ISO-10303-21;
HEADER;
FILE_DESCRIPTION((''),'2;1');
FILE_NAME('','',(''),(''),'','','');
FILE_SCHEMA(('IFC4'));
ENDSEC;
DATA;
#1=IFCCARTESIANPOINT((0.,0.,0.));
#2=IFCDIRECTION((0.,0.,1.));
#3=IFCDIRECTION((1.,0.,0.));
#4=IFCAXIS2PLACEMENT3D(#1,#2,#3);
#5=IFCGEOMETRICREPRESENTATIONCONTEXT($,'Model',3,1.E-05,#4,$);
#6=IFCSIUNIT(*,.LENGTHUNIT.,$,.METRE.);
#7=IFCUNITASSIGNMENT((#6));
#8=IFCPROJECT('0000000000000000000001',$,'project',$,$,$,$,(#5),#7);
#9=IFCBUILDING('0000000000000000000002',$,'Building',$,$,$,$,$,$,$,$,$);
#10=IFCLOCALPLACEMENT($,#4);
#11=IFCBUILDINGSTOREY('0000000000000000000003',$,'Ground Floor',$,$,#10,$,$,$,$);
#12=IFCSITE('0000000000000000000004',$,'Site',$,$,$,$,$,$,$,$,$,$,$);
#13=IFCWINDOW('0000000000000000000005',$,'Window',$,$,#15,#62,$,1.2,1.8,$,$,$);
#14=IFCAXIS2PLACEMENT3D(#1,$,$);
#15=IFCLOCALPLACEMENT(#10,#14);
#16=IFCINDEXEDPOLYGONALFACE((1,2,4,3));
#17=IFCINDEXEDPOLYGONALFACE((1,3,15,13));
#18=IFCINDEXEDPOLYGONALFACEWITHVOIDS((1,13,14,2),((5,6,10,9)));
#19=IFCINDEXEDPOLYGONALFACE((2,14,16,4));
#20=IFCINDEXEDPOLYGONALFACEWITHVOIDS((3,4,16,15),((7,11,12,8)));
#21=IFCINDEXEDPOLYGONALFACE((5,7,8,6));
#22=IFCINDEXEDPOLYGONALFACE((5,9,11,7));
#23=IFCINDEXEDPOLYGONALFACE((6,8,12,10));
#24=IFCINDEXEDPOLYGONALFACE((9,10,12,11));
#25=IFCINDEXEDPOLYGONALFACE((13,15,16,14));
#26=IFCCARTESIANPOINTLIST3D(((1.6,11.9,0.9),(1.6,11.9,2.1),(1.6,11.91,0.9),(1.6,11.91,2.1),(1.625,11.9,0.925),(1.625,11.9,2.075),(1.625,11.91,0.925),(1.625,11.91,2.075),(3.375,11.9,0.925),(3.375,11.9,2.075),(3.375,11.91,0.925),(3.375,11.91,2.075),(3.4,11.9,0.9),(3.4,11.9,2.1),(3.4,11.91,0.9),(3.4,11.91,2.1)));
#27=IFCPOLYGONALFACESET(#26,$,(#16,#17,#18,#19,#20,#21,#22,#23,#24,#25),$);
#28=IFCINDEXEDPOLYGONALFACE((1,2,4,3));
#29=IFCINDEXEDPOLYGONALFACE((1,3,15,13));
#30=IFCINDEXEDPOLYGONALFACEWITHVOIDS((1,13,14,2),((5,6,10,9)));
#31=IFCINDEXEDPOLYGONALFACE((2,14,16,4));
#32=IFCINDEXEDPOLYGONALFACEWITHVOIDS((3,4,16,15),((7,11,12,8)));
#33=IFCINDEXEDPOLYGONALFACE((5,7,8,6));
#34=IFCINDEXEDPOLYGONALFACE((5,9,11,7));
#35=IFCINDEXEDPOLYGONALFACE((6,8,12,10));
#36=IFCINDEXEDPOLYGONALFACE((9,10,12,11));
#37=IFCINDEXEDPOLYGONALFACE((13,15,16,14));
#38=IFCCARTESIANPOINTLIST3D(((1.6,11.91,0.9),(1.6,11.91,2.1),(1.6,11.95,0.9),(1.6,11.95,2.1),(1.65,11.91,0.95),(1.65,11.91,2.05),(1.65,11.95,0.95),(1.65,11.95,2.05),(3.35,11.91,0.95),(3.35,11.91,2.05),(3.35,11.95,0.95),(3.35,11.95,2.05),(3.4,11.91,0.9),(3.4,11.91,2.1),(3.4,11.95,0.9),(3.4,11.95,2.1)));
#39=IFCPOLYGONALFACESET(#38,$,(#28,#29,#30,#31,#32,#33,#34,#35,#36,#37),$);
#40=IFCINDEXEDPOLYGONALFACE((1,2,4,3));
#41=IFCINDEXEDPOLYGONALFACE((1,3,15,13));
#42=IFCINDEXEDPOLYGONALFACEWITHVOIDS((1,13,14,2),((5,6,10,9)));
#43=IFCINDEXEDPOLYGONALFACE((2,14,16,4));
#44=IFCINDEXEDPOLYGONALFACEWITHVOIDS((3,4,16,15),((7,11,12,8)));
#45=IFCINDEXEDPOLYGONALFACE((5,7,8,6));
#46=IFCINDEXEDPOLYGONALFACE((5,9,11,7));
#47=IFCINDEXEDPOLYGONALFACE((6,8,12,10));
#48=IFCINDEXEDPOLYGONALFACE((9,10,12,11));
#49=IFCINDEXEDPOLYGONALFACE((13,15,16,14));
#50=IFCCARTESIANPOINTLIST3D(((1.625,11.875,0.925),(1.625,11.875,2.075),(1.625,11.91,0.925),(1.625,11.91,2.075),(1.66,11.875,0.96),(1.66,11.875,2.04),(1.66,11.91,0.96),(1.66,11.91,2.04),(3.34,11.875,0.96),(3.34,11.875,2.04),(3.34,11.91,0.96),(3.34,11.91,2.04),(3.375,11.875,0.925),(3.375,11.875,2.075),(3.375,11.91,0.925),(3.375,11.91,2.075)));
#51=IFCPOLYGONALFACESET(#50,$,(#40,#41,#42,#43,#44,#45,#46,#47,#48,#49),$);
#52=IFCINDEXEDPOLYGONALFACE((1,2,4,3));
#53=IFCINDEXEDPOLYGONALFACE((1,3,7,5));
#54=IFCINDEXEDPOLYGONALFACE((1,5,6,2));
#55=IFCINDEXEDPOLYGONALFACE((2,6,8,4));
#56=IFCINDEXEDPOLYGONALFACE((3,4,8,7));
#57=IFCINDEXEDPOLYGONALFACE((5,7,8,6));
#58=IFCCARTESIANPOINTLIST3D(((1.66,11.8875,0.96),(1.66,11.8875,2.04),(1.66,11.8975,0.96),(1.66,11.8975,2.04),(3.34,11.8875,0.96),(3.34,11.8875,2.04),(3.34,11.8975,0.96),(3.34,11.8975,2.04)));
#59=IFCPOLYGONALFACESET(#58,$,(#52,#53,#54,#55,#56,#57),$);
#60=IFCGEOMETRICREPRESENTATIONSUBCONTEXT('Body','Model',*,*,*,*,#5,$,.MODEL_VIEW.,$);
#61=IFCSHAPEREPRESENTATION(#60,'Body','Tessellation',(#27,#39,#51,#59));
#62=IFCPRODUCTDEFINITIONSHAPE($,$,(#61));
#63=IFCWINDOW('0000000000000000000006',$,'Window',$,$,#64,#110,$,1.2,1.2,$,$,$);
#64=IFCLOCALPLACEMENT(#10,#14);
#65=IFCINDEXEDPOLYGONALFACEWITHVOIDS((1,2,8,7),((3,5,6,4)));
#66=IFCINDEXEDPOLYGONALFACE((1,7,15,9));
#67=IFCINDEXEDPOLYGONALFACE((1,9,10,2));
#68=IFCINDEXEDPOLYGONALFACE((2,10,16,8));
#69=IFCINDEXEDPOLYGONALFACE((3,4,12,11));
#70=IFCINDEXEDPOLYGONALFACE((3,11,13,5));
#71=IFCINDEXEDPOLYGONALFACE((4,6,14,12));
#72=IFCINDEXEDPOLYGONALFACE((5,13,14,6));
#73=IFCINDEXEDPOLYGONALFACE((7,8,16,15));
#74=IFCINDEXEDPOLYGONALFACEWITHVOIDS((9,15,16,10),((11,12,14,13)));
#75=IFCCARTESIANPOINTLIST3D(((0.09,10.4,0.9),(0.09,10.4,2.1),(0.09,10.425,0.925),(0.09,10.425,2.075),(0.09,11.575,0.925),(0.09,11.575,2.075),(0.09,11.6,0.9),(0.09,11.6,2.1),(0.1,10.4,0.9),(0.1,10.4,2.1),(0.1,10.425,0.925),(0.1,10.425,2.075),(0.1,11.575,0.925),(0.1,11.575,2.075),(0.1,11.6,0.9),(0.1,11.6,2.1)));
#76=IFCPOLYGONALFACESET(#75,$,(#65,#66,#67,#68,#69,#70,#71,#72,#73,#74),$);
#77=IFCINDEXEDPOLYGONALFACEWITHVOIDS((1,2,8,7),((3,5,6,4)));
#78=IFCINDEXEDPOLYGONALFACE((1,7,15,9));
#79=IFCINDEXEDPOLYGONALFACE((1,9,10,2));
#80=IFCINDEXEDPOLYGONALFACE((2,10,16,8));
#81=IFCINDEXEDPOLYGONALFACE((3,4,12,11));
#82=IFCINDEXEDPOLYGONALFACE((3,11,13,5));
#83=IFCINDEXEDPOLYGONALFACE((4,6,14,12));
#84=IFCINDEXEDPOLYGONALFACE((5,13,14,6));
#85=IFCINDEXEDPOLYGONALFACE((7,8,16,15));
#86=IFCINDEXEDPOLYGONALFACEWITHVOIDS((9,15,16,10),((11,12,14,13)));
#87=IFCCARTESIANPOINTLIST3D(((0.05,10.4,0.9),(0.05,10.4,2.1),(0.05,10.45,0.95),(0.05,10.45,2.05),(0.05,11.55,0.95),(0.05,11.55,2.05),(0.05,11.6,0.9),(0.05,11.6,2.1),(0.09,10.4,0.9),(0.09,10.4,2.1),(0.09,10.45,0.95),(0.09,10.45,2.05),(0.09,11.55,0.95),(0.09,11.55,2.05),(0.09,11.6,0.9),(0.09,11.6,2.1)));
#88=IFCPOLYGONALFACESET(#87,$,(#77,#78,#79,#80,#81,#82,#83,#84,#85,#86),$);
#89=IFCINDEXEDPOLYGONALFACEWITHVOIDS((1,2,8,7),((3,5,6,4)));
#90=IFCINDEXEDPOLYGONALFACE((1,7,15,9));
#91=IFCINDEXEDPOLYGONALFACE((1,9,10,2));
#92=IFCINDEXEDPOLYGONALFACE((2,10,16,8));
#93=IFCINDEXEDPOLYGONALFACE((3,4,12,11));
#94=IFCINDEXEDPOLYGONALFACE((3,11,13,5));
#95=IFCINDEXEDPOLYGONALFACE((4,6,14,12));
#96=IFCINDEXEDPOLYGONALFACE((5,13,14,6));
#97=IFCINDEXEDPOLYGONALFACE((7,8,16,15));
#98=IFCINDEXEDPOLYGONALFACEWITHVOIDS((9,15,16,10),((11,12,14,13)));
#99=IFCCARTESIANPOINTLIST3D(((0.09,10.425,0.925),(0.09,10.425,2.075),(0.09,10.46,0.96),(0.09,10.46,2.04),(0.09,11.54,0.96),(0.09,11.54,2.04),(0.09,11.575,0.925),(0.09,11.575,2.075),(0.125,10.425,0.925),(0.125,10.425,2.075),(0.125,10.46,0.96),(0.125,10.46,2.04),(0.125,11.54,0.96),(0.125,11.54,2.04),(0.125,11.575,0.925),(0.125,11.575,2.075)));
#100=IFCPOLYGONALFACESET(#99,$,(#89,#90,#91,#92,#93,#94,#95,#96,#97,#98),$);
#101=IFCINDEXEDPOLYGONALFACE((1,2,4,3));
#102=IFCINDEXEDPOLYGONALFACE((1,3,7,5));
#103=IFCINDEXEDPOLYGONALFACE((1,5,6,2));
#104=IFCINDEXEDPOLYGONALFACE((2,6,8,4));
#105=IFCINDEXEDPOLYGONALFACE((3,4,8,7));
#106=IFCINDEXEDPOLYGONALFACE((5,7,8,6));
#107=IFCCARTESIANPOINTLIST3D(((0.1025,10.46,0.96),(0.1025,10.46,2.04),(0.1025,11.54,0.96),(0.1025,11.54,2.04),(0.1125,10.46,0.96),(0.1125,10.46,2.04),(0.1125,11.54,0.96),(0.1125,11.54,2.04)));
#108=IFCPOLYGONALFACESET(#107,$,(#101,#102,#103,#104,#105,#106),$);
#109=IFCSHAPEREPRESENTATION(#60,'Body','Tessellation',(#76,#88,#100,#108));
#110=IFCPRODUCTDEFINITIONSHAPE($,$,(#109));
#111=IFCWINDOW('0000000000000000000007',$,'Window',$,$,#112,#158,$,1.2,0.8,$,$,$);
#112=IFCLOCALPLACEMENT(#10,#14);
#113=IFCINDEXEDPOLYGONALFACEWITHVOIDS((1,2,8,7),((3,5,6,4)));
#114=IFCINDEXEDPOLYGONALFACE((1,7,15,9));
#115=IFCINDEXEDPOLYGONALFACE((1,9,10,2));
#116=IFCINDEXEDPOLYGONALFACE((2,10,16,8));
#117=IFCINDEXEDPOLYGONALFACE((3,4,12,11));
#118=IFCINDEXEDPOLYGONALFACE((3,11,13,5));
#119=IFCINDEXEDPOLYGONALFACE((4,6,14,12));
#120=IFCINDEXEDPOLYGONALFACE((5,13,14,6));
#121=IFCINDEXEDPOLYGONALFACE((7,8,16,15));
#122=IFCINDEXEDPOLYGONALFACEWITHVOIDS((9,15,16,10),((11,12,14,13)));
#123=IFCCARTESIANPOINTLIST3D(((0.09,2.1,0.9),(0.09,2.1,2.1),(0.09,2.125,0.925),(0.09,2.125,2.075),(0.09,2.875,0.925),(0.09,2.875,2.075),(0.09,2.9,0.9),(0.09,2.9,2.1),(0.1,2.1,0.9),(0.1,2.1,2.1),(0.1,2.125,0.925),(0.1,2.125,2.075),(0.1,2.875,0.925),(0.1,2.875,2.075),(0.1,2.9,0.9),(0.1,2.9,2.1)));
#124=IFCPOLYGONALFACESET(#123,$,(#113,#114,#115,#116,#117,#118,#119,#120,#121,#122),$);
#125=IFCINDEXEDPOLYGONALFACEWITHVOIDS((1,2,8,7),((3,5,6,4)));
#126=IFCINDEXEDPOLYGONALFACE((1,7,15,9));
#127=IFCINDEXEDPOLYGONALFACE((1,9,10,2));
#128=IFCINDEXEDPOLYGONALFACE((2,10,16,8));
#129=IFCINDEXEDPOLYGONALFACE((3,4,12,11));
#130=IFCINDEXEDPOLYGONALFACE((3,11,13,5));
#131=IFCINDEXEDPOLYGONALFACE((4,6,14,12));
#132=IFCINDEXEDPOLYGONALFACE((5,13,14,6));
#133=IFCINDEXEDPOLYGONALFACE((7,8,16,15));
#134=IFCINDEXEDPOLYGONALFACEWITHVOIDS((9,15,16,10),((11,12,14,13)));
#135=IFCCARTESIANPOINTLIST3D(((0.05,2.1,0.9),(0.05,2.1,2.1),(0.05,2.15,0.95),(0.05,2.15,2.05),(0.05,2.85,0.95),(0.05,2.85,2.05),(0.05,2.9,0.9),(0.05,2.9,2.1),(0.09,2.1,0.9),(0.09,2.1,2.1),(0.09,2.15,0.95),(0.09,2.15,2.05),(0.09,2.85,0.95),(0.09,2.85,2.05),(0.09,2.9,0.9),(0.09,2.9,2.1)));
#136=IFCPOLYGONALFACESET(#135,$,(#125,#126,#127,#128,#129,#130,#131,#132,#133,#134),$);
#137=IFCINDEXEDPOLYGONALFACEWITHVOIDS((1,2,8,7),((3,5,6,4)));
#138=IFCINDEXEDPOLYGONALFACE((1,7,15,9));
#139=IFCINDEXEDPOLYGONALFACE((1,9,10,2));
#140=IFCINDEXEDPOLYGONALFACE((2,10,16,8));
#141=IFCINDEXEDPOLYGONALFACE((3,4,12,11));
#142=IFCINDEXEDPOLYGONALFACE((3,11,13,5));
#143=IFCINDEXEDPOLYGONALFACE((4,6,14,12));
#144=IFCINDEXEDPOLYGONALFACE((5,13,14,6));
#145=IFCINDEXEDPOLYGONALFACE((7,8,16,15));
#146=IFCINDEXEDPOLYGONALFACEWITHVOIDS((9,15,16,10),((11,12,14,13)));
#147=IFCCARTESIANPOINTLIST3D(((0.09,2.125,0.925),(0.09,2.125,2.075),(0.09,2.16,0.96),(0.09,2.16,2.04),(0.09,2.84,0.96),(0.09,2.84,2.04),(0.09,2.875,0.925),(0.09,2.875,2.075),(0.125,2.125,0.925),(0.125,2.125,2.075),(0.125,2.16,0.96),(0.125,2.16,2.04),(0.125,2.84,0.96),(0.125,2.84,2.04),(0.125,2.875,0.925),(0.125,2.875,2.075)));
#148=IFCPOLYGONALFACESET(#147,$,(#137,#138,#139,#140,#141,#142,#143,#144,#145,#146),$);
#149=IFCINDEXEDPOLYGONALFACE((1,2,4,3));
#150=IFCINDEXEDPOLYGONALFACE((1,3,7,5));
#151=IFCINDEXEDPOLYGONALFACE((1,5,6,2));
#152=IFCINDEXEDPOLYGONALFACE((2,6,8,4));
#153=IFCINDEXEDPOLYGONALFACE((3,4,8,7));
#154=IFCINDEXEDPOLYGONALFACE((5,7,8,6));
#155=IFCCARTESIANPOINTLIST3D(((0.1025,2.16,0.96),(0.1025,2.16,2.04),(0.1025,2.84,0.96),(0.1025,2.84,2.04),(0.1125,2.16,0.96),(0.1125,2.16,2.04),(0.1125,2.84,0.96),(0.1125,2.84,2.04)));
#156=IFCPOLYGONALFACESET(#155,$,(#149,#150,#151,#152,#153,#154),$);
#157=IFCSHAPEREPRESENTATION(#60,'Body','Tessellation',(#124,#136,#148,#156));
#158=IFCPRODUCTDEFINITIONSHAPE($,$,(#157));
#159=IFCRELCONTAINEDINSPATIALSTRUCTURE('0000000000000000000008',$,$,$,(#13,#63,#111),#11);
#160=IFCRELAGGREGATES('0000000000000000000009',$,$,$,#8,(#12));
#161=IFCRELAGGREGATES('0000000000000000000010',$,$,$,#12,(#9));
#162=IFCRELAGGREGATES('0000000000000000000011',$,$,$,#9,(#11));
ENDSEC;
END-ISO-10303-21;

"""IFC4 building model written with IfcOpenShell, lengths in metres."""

from ifc_helpers import new_model, si_unit, frame, origin_with_axes, place, context, subcontext, project, spatial, line, indexed_curve, outline, extrude, element, save


model = new_model("IFC4")

# Units and contexts
model_context = context("Model", 3, precision=1e-05, world=origin_with_axes())
body_context = subcontext(model_context, "Body", "Model", "MODEL_VIEW")
ifc_project = project(units=[si_unit("LENGTHUNIT", "METRE")], contexts=[model_context])

# Site, building, storey
site = spatial("IfcSite", under=ifc_project, Name="Site")
building = spatial("IfcBuilding", under=site, Name="Building")
storey_placement = place(None, origin_with_axes())
storey = spatial("IfcBuildingStorey", under=building, at=storey_placement, Name="Ground Floor")

# Windows
window_1_placement = place(storey_placement, frame((3.4, 12.0, 0.9), z_axis=(0.0, 0.0, 1.0), x_axis=(-1.0, 0.0, 0.0)))
element("IfcWindow", 1, at=window_1_placement, inside=storey, Name="Window", OverallHeight=1.2, OverallWidth=1.8, context=body_context, shape_type="SweptSolid", body=[
    extrude(outline(indexed_curve([(0.0, 0.0), (1.8, 0.0), (1.8, 1.2), (0.0, 1.2)], segments=[line(1, 2, 3, 4, 1)]), holes=[indexed_curve([(0.025, 0.025), (1.775, 0.025), (1.775, 1.175), (0.025, 1.175)], segments=[line(1, 2, 3, 4, 1)])]), frame((0.0, 0.09, 0.0), z_axis=(0.0, -1.0, 0.0), x_axis=(1.0, 0.0, 0.0)), (0.0, 0.0, -1.0), 0.01),
    extrude(outline(indexed_curve([(0.0, 0.0), (1.8, 0.0), (1.8, 1.2), (0.0, 1.2)], segments=[line(1, 2, 3, 4, 1)]), holes=[indexed_curve([(0.05, 0.05), (1.75, 0.05), (1.75, 1.15), (0.05, 1.15)], segments=[line(1, 2, 3, 4, 1)])]), frame((0.0, 0.05, 0.0), z_axis=(0.0, -1.0, 0.0), x_axis=(1.0, 0.0, 0.0)), (0.0, 0.0, -1.0), 0.04),
    extrude(outline(indexed_curve([(0.0, 0.0), (1.75, 0.0), (1.75, 1.15), (0.0, 1.15)], segments=[line(1, 2, 3, 4, 1)]), holes=[indexed_curve([(0.035, 0.035), (1.715, 0.035), (1.715, 1.115), (0.035, 1.115)], segments=[line(1, 2, 3, 4, 1)])]), frame((0.025, 0.09, 0.025), z_axis=(0.0, -1.0, 0.0), x_axis=(1.0, 0.0, 0.0)), (0.0, 0.0, -1.0), 0.035),
    extrude(outline(indexed_curve([(0.035, 0.035), (1.715, 0.035), (1.715, 1.115), (0.035, 1.115)], segments=[line(1, 2, 3, 4, 1)])), frame((0.025, 0.1025, 0.025), z_axis=(0.0, -1.0, 0.0), x_axis=(1.0, 0.0, 0.0)), (0.0, 0.0, -1.0), 0.01),
])
window_2_placement = place(storey_placement, frame((0.0, 11.6, 0.9), z_axis=(0.0, 0.0, 1.0), x_axis=(0.0, -1.0, 0.0)))
element("IfcWindow", 2, at=window_2_placement, inside=storey, Name="Window", OverallHeight=1.2, OverallWidth=1.2, context=body_context, shape_type="SweptSolid", body=[
    extrude(outline(indexed_curve([(0.0, 0.0), (1.2, 0.0), (1.2, 1.2), (0.0, 1.2)], segments=[line(1, 2, 3, 4, 1)]), holes=[indexed_curve([(0.025, 0.025), (1.175, 0.025), (1.175, 1.175), (0.025, 1.175)], segments=[line(1, 2, 3, 4, 1)])]), frame((0.0, 0.09, 0.0), z_axis=(0.0, -1.0, 0.0), x_axis=(1.0, 0.0, 0.0)), (0.0, 0.0, -1.0), 0.01),
    extrude(outline(indexed_curve([(0.0, 0.0), (1.2, 0.0), (1.2, 1.2), (0.0, 1.2)], segments=[line(1, 2, 3, 4, 1)]), holes=[indexed_curve([(0.05, 0.05), (1.15, 0.05), (1.15, 1.15), (0.05, 1.15)], segments=[line(1, 2, 3, 4, 1)])]), frame((0.0, 0.05, 0.0), z_axis=(0.0, -1.0, 0.0), x_axis=(1.0, 0.0, 0.0)), (0.0, 0.0, -1.0), 0.04),
    extrude(outline(indexed_curve([(0.0, 0.0), (1.15, 0.0), (1.15, 1.15), (0.0, 1.15)], segments=[line(1, 2, 3, 4, 1)]), holes=[indexed_curve([(0.035, 0.035), (1.115, 0.035), (1.115, 1.115), (0.035, 1.115)], segments=[line(1, 2, 3, 4, 1)])]), frame((0.025, 0.09, 0.025), z_axis=(0.0, -1.0, 0.0), x_axis=(1.0, 0.0, 0.0)), (0.0, 0.0, -1.0), 0.035),
    extrude(outline(indexed_curve([(0.035, 0.035), (1.115, 0.035), (1.115, 1.115), (0.035, 1.115)], segments=[line(1, 2, 3, 4, 1)])), frame((0.025, 0.1025, 0.025), z_axis=(0.0, -1.0, 0.0), x_axis=(1.0, 0.0, 0.0)), (0.0, 0.0, -1.0), 0.01),
])
window_3_placement = place(storey_placement, frame((0.0, 2.9, 0.9), z_axis=(0.0, 0.0, 1.0), x_axis=(0.0, -1.0, 0.0)))
element("IfcWindow", 3, at=window_3_placement, inside=storey, Name="Window", OverallHeight=1.2, OverallWidth=0.8, context=body_context, shape_type="SweptSolid", body=[
    extrude(outline(indexed_curve([(0.0, 0.0), (0.8, 0.0), (0.8, 1.2), (0.0, 1.2)], segments=[line(1, 2, 3, 4, 1)]), holes=[indexed_curve([(0.025, 0.025), (0.775, 0.025), (0.775, 1.175), (0.025, 1.175)], segments=[line(1, 2, 3, 4, 1)])]), frame((0.0, 0.09, 0.0), z_axis=(0.0, -1.0, 0.0), x_axis=(1.0, 0.0, 0.0)), (0.0, 0.0, -1.0), 0.01),
    extrude(outline(indexed_curve([(0.0, 0.0), (0.8, 0.0), (0.8, 1.2), (0.0, 1.2)], segments=[line(1, 2, 3, 4, 1)]), holes=[indexed_curve([(0.05, 0.05), (0.75, 0.05), (0.75, 1.15), (0.05, 1.15)], segments=[line(1, 2, 3, 4, 1)])]), frame((0.0, 0.05, 0.0), z_axis=(0.0, -1.0, 0.0), x_axis=(1.0, 0.0, 0.0)), (0.0, 0.0, -1.0), 0.04),
    extrude(outline(indexed_curve([(0.0, 0.0), (0.75, 0.0), (0.75, 1.15), (0.0, 1.15)], segments=[line(1, 2, 3, 4, 1)]), holes=[indexed_curve([(0.035, 0.035), (0.715, 0.035), (0.715, 1.115), (0.035, 1.115)], segments=[line(1, 2, 3, 4, 1)])]), frame((0.025, 0.09, 0.025), z_axis=(0.0, -1.0, 0.0), x_axis=(1.0, 0.0, 0.0)), (0.0, 0.0, -1.0), 0.035),
    extrude(outline(indexed_curve([(0.035, 0.035), (0.715, 0.035), (0.715, 1.115), (0.035, 1.115)], segments=[line(1, 2, 3, 4, 1)])), frame((0.025, 0.1025, 0.025), z_axis=(0.0, -1.0, 0.0), x_axis=(1.0, 0.0, 0.0)), (0.0, 0.0, -1.0), 0.01),
])

save(model, "model.ifc")
